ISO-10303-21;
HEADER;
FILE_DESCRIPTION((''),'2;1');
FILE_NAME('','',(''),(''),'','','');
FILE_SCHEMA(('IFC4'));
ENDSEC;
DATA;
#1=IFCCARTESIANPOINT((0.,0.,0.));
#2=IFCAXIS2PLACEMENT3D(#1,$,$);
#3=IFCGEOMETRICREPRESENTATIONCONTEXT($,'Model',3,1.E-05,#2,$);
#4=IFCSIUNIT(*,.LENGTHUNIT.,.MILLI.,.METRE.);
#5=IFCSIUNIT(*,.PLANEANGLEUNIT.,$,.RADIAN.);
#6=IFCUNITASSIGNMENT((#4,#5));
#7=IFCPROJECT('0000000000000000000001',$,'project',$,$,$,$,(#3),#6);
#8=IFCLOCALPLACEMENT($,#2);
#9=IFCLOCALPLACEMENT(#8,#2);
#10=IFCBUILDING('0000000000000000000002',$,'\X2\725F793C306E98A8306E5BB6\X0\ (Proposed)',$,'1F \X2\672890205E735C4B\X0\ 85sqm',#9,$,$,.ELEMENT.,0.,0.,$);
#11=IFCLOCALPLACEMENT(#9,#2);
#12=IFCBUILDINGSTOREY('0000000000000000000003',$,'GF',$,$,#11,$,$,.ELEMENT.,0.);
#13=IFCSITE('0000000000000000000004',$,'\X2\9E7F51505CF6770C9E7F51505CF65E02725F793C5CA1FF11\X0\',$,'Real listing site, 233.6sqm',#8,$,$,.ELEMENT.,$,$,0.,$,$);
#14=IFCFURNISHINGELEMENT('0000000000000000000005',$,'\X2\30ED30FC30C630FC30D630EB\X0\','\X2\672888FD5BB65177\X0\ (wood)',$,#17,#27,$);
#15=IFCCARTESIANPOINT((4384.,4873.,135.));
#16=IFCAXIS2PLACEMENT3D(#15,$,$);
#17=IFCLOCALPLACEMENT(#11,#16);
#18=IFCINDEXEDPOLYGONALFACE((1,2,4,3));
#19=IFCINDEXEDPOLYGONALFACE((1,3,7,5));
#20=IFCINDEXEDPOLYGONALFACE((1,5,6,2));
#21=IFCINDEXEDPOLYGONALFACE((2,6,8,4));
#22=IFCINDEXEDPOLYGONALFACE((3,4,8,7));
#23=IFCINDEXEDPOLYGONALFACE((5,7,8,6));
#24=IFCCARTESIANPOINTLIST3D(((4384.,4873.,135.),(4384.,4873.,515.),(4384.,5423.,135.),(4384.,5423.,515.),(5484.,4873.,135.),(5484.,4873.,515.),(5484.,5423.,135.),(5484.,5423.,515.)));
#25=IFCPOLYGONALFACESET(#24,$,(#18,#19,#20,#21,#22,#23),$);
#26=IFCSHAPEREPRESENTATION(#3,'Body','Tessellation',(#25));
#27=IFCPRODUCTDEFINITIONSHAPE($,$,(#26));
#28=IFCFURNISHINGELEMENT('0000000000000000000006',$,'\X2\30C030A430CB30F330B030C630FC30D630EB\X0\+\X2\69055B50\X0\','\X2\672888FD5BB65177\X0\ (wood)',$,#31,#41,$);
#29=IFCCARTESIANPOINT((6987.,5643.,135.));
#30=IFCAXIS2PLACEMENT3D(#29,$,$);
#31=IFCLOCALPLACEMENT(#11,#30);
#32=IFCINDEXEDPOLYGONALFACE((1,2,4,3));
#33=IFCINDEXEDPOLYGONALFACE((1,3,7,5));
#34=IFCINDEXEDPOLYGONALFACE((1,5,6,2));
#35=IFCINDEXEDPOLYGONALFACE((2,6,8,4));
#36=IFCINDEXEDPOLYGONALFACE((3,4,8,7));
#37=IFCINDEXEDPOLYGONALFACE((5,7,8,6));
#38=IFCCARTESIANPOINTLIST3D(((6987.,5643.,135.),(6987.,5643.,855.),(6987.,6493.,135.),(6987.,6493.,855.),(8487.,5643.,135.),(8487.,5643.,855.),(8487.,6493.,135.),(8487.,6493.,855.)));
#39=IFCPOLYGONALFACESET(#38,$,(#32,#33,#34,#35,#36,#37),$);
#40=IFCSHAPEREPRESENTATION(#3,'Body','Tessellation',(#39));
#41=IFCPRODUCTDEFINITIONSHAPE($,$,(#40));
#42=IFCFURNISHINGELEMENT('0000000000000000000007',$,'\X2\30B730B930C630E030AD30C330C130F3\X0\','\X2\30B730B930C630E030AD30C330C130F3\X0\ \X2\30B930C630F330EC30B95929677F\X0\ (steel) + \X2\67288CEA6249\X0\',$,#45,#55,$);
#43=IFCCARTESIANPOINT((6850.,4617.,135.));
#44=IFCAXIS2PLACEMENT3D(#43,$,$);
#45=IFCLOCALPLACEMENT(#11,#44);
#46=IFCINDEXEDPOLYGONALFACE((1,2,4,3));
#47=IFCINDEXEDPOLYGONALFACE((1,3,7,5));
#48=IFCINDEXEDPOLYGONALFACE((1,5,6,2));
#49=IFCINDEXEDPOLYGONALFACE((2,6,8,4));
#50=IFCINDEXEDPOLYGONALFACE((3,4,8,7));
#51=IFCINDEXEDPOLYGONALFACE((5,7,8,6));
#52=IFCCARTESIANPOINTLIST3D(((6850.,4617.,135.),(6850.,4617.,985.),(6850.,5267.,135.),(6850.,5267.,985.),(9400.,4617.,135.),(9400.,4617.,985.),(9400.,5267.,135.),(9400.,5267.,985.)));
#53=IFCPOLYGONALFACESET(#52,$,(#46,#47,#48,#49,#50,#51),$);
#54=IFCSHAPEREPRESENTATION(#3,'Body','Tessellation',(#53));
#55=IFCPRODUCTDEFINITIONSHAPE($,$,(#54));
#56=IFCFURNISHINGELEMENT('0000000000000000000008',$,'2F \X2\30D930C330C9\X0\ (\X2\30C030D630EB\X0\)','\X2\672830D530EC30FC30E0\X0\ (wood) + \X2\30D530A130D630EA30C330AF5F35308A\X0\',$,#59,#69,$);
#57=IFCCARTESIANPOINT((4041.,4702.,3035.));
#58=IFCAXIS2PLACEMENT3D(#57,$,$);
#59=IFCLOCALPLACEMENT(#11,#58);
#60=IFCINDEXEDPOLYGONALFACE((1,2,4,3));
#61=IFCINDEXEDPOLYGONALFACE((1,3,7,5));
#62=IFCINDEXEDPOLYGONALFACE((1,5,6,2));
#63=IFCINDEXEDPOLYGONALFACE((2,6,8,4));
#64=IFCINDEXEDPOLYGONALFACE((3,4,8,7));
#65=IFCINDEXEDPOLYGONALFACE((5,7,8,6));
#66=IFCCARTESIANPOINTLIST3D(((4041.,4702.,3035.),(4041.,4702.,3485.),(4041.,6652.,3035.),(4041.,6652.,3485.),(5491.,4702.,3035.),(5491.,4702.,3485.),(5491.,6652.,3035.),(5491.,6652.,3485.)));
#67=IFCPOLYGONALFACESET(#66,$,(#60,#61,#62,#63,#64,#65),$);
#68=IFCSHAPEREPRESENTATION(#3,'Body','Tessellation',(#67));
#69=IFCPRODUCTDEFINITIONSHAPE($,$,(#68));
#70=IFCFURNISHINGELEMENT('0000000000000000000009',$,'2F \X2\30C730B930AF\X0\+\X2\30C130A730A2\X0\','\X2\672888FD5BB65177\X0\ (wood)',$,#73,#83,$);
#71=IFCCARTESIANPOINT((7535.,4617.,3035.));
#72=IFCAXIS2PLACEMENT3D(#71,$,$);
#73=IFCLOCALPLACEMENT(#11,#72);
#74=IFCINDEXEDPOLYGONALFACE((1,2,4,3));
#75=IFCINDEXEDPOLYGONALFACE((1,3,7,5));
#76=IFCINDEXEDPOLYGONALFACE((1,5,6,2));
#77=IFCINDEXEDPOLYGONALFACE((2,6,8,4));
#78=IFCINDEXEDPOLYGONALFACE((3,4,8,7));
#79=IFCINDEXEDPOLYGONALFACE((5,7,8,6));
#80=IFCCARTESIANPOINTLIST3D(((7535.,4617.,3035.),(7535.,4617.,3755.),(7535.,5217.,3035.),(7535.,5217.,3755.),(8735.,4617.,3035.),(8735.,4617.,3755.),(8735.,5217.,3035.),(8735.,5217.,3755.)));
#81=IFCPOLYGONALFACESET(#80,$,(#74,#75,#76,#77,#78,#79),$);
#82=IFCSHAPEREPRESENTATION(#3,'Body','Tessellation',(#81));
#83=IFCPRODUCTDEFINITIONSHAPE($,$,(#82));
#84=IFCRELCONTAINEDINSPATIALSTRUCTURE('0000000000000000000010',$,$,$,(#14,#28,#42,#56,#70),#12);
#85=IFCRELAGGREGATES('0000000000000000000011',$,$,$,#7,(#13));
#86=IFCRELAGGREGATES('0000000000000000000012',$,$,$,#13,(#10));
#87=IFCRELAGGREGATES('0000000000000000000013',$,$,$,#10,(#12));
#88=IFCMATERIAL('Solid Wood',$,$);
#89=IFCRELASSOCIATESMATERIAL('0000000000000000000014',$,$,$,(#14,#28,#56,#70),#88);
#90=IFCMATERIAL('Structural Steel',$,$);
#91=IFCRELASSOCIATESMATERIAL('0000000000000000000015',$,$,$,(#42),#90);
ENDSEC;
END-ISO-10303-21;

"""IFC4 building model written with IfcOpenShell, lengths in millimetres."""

from ifc_helpers import new_model, si_unit, frame, frame_2d, origin, place, context, project, spatial, rectangle, extrude, material, element, save


model = new_model("IFC4")

# Units and contexts
model_context = context("Model", 3, precision=1e-05, world=origin())
ifc_project = project(units=[si_unit("LENGTHUNIT", "METRE", prefix="MILLI"), si_unit("PLANEANGLEUNIT", "RADIAN")], contexts=[model_context])

# Site, building, storey
site_placement = place(None, origin())
site = spatial("IfcSite", under=ifc_project, at=site_placement, Name="鹿児島県鹿児島市牟礼岡１", ObjectType="Real listing site, 233.6sqm", CompositionType="ELEMENT", RefElevation=0.0)
building_placement = place(site_placement, origin())
building = spatial("IfcBuilding", under=site, at=building_placement, Name="牟礼の風の家 (Proposed)", ObjectType="1F 木造平屋 85sqm", CompositionType="ELEMENT", ElevationOfRefHeight=0.0, ElevationOfTerrain=0.0)
storey_placement = place(building_placement, origin())
storey = spatial("IfcBuildingStorey", under=building, at=storey_placement, Name="GF", CompositionType="ELEMENT", Elevation=0.0)

# Shared definitions
ifc_material_1 = material(Name="Solid Wood")

# Shared definitions
ifc_material_2 = material(Name="Structural Steel")

# Furnishing elements
furnishing_1_placement = place(storey_placement, frame((4384.0, 4873.0, 135.0)))
element("IfcFurnishingElement", 1, at=furnishing_1_placement, inside=storey, material=ifc_material_1, Name="ローテーブル", Description="木製家具 (wood)", context=model_context, shape_type="SweptSolid", body=[
    extrude(rectangle(XDim=1100.0, YDim=550.0, at=frame_2d((550.0, 275.0))), frame((4384.0, 4873.0, 135.0)), (0.0, 0.0, 1.0), 380.0),
])
furnishing_2_placement = place(storey_placement, frame((6987.0, 5643.0, 135.0)))
element("IfcFurnishingElement", 2, at=furnishing_2_placement, inside=storey, material=ifc_material_1, Name="ダイニングテーブル+椅子", Description="木製家具 (wood)", context=model_context, shape_type="SweptSolid", body=[
    extrude(rectangle(XDim=1500.0, YDim=850.0, at=frame_2d((750.0, 425.0))), frame((6987.0, 5643.0, 135.0)), (0.0, 0.0, 1.0), 720.0),
])
furnishing_3_placement = place(storey_placement, frame((6850.0, 4617.0, 135.0)))
element("IfcFurnishingElement", 3, at=furnishing_3_placement, inside=storey, material=ifc_material_2, Name="システムキッチン", Description="システムキッチン ステンレス天板 (steel) + 木質扉", context=model_context, shape_type="SweptSolid", body=[
    extrude(rectangle(XDim=2550.0, YDim=650.0, at=frame_2d((1275.0, 325.0))), frame((6850.0, 4617.0, 135.0)), (0.0, 0.0, 1.0), 850.0),
])
furnishing_4_placement = place(storey_placement, frame((4041.0, 4702.0, 3035.0)))
element("IfcFurnishingElement", 4, at=furnishing_4_placement, inside=storey, material=ifc_material_1, Name="2F ベッド (ダブル)", Description="木フレーム (wood) + ファブリック張り", context=model_context, shape_type="SweptSolid", body=[
    extrude(rectangle(XDim=1450.0, YDim=1950.0, at=frame_2d((725.0, 975.0))), frame((4041.0, 4702.0, 3035.0)), (0.0, 0.0, 1.0), 450.0),
])
furnishing_5_placement = place(storey_placement, frame((7535.0, 4617.0, 3035.0)))
element("IfcFurnishingElement", 5, at=furnishing_5_placement, inside=storey, material=ifc_material_1, Name="2F デスク+チェア", Description="木製家具 (wood)", context=model_context, shape_type="SweptSolid", body=[
    extrude(rectangle(XDim=1200.0, YDim=600.0, at=frame_2d((600.0, 300.0))), frame((7535.0, 4617.0, 3035.0)), (0.0, 0.0, 1.0), 720.0),
])

save(model, "model.ifc")
